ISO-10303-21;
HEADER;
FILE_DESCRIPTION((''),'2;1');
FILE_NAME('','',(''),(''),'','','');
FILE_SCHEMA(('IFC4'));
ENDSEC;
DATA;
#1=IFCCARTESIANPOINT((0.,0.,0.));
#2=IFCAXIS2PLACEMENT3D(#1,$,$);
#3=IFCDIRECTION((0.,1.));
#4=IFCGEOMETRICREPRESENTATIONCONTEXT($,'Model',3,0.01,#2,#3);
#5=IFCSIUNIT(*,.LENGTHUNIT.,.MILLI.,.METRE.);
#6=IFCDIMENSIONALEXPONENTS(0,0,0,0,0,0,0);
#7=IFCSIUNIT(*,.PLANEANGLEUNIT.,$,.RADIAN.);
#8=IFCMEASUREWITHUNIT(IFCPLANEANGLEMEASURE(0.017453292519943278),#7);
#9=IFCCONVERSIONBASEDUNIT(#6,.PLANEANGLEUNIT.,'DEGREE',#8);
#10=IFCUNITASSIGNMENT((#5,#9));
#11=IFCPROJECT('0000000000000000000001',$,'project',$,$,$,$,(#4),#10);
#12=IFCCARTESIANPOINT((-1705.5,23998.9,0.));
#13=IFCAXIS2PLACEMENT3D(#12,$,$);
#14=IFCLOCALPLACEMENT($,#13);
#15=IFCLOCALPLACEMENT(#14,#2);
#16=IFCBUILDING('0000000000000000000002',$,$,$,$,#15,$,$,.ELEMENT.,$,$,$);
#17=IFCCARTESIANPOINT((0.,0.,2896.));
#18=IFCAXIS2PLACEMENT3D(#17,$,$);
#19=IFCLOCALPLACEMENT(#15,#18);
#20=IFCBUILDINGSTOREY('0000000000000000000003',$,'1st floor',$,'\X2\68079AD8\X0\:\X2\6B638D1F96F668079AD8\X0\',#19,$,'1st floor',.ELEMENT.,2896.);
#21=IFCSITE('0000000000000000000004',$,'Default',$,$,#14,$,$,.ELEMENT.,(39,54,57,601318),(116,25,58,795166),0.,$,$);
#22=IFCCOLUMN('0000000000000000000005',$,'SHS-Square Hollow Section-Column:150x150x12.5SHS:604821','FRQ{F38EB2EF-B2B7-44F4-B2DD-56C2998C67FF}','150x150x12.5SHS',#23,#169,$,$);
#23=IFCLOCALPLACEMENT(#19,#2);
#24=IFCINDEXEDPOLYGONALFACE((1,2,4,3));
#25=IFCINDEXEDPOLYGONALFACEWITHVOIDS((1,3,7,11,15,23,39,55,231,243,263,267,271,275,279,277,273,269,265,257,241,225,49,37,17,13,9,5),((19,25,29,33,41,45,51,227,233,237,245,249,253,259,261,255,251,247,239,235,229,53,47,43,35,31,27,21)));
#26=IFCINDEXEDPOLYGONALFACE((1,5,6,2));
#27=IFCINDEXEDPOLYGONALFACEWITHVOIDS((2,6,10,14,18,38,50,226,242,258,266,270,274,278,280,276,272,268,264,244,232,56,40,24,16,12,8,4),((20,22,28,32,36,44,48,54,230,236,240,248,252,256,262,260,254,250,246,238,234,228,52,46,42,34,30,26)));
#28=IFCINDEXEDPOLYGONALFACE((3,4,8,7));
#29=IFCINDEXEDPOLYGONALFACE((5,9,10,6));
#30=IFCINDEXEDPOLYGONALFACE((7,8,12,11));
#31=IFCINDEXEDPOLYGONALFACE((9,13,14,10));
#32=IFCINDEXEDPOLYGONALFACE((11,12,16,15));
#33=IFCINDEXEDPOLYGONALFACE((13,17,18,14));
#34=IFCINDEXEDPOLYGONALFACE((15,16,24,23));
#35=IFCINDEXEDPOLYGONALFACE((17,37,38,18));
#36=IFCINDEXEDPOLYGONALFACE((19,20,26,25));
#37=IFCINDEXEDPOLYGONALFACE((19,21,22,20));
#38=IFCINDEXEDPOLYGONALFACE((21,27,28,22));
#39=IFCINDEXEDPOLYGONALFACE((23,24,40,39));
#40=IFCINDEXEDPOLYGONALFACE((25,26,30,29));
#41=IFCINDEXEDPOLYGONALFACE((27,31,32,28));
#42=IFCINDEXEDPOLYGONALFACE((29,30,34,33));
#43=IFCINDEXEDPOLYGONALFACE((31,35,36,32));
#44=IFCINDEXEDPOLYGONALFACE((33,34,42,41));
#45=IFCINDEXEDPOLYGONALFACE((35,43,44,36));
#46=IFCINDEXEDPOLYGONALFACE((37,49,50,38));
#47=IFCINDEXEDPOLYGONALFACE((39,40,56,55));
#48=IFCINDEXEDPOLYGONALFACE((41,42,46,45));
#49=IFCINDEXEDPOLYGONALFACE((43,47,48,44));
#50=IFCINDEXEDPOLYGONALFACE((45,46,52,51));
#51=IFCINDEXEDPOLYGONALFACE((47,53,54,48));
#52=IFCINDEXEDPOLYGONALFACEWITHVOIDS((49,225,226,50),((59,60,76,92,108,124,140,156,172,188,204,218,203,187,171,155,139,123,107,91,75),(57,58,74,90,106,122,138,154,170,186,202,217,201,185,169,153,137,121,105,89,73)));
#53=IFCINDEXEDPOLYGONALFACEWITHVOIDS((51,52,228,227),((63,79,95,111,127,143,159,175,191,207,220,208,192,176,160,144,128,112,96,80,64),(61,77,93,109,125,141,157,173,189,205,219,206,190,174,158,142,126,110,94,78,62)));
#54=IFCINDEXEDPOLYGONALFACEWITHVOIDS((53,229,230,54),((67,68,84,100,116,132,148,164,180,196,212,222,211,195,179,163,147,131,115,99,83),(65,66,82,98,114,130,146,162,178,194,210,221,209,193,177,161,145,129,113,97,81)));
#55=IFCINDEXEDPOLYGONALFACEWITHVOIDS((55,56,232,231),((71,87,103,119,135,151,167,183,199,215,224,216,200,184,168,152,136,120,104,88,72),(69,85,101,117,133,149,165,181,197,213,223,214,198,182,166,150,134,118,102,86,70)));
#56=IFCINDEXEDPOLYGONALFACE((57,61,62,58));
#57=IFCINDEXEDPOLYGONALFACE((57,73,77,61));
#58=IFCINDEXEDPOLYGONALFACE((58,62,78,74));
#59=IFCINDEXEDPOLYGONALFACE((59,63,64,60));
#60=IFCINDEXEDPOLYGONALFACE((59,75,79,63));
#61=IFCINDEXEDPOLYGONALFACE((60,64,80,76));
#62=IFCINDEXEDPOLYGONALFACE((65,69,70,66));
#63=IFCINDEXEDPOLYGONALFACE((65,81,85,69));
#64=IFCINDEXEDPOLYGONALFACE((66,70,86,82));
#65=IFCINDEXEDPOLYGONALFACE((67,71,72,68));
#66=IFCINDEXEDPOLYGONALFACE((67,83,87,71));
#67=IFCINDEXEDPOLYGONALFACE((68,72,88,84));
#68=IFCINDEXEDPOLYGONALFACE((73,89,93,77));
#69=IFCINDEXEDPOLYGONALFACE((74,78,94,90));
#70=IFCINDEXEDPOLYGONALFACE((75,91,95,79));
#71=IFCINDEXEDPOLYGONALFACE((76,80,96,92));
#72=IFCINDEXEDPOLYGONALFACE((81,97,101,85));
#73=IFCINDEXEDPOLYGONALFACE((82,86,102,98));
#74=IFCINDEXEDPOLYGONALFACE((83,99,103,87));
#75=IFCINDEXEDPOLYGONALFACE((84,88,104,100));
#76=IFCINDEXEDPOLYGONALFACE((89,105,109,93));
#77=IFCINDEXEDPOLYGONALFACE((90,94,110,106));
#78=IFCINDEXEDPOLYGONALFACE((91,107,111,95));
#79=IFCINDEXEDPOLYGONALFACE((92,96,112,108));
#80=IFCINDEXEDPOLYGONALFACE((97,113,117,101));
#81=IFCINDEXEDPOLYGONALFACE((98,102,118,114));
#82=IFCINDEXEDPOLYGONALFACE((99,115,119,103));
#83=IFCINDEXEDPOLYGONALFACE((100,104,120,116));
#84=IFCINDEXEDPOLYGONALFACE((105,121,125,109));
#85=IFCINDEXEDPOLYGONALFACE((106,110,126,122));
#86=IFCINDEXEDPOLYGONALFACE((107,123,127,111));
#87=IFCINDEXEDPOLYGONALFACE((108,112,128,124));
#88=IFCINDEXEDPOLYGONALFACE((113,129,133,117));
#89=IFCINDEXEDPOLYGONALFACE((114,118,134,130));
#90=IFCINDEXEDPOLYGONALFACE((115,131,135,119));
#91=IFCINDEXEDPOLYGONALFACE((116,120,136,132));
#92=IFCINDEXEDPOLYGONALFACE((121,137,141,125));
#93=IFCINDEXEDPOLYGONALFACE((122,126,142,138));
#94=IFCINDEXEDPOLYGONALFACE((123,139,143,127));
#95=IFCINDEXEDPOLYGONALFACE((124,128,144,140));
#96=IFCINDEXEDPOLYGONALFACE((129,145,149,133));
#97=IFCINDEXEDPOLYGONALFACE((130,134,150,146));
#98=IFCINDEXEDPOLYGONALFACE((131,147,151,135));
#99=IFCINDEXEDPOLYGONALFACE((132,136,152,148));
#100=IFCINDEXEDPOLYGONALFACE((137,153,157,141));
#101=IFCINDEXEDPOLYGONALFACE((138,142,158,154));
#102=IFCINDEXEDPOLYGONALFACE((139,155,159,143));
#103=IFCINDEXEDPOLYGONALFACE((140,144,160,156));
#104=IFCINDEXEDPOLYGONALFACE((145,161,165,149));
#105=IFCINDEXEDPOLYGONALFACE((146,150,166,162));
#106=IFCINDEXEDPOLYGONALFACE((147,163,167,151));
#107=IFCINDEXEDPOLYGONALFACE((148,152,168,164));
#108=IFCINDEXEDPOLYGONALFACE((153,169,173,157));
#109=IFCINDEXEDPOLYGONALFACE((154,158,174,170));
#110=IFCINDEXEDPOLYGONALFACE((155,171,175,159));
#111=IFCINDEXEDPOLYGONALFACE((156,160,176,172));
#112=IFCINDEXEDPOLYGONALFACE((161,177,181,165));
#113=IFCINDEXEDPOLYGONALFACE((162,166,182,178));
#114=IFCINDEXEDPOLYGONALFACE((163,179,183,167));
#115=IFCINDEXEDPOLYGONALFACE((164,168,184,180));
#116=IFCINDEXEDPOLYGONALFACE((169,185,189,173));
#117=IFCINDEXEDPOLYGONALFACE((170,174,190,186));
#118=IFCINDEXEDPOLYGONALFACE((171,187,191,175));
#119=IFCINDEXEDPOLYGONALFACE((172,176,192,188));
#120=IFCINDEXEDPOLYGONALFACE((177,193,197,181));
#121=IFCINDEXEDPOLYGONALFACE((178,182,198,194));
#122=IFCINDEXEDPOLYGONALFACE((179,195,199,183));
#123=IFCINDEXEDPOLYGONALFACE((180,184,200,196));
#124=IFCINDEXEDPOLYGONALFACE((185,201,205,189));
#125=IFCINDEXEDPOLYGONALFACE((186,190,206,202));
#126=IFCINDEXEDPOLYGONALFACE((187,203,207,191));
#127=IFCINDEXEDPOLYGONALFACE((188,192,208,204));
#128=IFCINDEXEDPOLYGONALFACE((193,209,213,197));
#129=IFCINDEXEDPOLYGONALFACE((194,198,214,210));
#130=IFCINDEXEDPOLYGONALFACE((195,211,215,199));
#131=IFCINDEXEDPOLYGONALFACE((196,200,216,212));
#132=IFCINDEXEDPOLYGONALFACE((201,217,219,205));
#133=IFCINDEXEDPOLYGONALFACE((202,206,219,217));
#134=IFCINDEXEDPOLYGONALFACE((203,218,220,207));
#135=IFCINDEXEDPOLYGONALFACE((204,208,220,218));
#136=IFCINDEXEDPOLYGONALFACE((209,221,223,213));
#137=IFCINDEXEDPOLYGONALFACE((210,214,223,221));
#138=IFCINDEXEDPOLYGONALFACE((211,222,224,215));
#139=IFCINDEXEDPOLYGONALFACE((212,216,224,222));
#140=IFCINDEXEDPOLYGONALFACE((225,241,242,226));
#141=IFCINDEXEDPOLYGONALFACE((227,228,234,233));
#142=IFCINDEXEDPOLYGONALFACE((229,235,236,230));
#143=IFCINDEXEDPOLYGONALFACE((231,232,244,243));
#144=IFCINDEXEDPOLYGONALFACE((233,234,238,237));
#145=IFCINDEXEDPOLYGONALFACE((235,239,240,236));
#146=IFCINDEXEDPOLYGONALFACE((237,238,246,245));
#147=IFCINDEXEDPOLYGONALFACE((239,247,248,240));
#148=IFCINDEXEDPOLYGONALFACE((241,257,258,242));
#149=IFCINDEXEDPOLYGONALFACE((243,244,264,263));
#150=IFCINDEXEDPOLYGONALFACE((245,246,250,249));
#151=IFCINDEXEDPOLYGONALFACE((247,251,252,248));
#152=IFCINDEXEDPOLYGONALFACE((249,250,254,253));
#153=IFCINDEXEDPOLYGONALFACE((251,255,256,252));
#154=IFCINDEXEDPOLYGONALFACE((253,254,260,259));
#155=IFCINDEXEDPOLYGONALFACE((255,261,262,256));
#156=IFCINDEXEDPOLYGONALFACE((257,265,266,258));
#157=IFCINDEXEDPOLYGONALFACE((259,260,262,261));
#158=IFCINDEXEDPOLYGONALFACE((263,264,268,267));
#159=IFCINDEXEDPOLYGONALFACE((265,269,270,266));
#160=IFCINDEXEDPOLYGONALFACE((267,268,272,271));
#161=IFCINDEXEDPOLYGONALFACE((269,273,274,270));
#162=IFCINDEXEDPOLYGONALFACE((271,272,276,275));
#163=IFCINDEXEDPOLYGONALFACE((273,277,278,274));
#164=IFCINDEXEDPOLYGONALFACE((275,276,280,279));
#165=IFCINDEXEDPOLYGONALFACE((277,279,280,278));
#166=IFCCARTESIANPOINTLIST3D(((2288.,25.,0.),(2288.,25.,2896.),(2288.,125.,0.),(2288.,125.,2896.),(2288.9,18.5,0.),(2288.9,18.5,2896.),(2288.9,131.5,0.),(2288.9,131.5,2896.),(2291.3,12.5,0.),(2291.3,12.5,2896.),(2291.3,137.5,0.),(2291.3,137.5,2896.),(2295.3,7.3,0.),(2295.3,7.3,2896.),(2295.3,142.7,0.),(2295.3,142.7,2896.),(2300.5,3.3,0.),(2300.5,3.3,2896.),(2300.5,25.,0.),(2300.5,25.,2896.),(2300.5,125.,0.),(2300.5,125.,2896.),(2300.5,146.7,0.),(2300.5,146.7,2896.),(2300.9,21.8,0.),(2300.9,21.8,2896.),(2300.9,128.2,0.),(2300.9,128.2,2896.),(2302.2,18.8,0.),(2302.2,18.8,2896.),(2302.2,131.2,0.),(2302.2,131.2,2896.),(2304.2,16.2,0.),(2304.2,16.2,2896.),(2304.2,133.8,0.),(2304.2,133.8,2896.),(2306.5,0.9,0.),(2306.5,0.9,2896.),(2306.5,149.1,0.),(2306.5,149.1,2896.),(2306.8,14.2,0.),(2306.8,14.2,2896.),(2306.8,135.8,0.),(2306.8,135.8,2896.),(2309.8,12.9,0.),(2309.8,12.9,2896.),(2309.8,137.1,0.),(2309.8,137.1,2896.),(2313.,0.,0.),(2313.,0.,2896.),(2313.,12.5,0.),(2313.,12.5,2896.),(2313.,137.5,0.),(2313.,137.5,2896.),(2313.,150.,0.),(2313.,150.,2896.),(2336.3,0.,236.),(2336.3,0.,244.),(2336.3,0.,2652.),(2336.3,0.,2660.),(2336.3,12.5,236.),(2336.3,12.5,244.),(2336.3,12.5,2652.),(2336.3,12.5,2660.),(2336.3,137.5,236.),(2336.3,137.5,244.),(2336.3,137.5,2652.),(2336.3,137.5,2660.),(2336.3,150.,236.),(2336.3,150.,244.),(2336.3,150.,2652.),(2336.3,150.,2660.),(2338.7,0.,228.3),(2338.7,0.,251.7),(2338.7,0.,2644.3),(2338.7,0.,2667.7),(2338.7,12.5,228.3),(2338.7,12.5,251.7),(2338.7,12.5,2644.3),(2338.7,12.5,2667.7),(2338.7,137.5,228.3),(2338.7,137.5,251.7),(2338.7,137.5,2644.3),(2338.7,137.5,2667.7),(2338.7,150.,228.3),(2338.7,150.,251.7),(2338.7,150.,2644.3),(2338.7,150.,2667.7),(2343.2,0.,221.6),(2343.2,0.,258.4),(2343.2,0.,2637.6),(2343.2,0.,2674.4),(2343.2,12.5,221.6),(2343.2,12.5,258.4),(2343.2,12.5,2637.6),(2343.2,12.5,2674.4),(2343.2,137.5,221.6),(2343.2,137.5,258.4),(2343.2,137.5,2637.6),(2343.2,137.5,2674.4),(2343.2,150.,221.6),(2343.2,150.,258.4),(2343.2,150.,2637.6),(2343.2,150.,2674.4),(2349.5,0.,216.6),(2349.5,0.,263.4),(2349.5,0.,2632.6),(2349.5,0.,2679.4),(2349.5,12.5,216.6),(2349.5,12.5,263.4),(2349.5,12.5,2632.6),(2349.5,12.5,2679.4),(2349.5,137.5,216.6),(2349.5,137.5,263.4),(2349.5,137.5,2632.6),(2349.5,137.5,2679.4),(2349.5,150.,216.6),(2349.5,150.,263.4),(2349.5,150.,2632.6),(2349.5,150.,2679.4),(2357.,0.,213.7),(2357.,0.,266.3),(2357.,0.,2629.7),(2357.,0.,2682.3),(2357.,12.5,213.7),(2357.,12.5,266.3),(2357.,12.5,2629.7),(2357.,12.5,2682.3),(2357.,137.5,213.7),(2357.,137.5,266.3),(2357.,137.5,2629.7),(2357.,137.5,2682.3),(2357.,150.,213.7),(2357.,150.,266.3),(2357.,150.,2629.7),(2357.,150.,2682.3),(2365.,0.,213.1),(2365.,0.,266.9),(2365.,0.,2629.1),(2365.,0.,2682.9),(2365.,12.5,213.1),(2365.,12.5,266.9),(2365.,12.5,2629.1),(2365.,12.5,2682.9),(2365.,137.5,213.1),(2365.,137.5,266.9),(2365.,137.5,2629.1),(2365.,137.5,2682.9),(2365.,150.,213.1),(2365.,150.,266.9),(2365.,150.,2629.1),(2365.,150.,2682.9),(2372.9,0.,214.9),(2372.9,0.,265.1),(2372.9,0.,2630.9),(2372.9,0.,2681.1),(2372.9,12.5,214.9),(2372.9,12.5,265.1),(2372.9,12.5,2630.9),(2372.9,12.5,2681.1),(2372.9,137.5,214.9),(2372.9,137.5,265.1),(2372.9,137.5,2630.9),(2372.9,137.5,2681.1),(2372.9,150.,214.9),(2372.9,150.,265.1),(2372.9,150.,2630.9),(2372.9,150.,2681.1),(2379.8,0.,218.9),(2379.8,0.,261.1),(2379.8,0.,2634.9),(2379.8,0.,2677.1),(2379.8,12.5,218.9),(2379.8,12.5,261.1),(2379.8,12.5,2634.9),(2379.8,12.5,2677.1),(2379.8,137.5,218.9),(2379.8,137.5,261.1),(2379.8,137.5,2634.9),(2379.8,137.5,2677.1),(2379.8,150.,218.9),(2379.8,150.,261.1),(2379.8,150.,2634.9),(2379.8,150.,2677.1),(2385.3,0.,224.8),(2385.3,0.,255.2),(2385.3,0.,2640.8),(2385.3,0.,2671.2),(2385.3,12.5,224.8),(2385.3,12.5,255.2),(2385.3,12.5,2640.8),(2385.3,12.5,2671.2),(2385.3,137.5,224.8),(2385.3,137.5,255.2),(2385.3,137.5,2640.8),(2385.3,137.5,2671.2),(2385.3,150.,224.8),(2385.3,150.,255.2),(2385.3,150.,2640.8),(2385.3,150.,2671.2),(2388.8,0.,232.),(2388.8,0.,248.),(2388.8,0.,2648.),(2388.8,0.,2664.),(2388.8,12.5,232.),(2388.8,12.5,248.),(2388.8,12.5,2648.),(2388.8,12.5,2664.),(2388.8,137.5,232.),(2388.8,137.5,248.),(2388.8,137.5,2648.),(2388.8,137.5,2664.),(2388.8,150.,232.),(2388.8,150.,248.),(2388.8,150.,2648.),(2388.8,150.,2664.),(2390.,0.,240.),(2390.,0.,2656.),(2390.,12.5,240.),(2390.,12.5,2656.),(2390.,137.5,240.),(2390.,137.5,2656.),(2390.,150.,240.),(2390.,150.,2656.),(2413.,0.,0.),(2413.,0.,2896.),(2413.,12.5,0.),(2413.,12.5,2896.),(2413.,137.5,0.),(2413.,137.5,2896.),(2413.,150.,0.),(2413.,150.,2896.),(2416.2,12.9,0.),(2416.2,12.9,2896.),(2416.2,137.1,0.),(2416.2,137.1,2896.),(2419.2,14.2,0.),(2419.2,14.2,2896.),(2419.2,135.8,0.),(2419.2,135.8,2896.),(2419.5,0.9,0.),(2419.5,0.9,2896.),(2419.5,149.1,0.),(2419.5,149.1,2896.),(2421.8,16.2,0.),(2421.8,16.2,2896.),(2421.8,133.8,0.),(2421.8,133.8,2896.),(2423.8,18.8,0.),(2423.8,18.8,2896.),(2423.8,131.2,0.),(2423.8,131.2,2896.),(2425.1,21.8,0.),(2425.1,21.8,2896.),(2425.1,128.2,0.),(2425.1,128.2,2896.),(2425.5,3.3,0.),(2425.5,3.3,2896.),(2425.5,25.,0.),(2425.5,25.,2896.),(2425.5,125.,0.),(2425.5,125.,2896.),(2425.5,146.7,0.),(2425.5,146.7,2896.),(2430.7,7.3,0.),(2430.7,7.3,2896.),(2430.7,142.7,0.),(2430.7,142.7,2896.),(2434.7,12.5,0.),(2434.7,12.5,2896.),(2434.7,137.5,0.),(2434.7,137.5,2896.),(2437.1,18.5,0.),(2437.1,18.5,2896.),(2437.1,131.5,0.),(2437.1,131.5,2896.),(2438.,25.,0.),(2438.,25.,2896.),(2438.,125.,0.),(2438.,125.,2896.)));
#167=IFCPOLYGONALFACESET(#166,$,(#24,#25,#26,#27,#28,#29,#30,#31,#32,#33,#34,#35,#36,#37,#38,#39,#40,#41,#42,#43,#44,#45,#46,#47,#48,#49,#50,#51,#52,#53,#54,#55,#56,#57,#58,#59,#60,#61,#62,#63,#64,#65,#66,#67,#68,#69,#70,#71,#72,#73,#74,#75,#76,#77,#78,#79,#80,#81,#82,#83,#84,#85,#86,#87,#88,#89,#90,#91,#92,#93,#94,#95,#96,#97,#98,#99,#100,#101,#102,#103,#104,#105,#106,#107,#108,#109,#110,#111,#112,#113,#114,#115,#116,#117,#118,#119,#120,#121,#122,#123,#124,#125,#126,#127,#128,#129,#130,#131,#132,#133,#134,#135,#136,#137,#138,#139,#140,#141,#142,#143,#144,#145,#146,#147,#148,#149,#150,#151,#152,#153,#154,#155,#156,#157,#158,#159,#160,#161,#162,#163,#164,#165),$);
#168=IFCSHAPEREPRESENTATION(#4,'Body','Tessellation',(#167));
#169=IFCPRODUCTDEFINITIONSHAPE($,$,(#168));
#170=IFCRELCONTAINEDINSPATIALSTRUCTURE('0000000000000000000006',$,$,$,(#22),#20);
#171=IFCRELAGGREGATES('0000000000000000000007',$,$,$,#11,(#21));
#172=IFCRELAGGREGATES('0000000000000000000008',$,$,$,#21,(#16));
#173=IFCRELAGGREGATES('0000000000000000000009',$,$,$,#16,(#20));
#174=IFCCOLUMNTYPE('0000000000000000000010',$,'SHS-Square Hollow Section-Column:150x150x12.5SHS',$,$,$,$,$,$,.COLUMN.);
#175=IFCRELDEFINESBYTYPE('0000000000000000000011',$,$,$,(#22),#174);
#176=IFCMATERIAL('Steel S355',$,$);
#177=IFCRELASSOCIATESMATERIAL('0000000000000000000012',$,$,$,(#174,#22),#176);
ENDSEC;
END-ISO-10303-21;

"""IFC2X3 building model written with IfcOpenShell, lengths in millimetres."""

from ifc_helpers import new_model, entity, si_unit, converted_unit, direction, frame, frame_2d, origin, origin_2d, place, context, project, spatial, circle_curve, hollow_rectangle, outline, extrude, material, type_object, element, save


model = new_model("IFC2X3")

# Units and contexts
model_context = context("Model", 3, precision=0.01, world=origin(), true_north=direction((0.0, 1.0)))
ifc_project = project(units=[si_unit("LENGTHUNIT", "METRE", prefix="MILLI"), converted_unit("PLANEANGLEUNIT", "DEGREE", entity("IfcPlaneAngleMeasure", 0.017453292519943278), si_unit("PLANEANGLEUNIT", "RADIAN"), dimensions=[0, 0, 0, 0, 0, 0, 0])], contexts=[model_context])

# Site, building, storey
site_placement = place(None, frame((-1705.5, 23998.9, 0.0)))
site = spatial("IfcSite", under=ifc_project, at=site_placement, Name="Default", CompositionType="ELEMENT", RefLatitude=(39, 54, 57, 601318), RefLongitude=(116, 25, 58, 795166), RefElevation=0.0)
building_placement = place(site_placement, origin())
building = spatial("IfcBuilding", under=site, at=building_placement, CompositionType="ELEMENT")
storey_placement = place(building_placement, frame((0.0, 0.0, 2896.0)))
storey = spatial("IfcBuildingStorey", under=building, at=storey_placement, Name="1st floor", ObjectType="标高:正负零标高", LongName="1st floor", CompositionType="ELEMENT", Elevation=2896.0)

# Column, openings
ifc_material_1 = material(Name="Steel S355")
column_type_1 = type_object("IfcColumnType", Name="SHS-Square Hollow Section-Column:150x150x12.5SHS", PredefinedType="COLUMN", material=ifc_material_1)
column_1_placement = place(storey_placement, frame((2363.0, 75.0, 2896.0), z_axis=(0.0, 0.0, 1.0), x_axis=(0.0, -1.0, 0.0)))
column_1 = element("IfcColumn", 1, at=column_1_placement, inside=storey, type_object=column_type_1, material=ifc_material_1, Name="SHS-Square Hollow Section-Column:150x150x12.5SHS:604821", Description="FRQ{F38EB2EF-B2B7-44F4-B2DD-56C2998C67FF}", ObjectType="150x150x12.5SHS", context=model_context, shape_type="SweptSolid", body=[
    extrude(hollow_rectangle(XDim=150.0, YDim=150.0, WallThickness=12.5, InnerFilletRadius=12.5, OuterFilletRadius=25.0, at=origin_2d()), origin(), (0.0, 0.0, -1.0), 2896.0),
])
opening_1_placement = place(column_1_placement, frame((-175.1, 0.0, 0.0), z_axis=(1.0, 0.0, 0.0), x_axis=(0.0, 1.0, 0.0)))
element("IfcOpeningElement", 2, at=opening_1_placement, cuts=column_1, ObjectType="Opening", context=model_context, shape_type="SweptSolid", body=[
    extrude(outline(circle_curve(frame_2d((0.0, -240.0), x_axis=(1.0, 0.0)), 27.0)), origin(), (0.0, 0.0, 1.0), 350.2),
])
opening_2_placement = place(column_1_placement, frame((-175.1, 0.0, -2896.0), z_axis=(1.0, 0.0, 0.0), x_axis=(0.0, 1.0, 0.0)))
element("IfcOpeningElement", 3, at=opening_2_placement, cuts=column_1, ObjectType="Opening", context=model_context, shape_type="SweptSolid", body=[
    extrude(outline(circle_curve(frame_2d((0.0, 240.0), x_axis=(1.0, 0.0)), 27.0)), origin(), (0.0, 0.0, 1.0), 350.2),
])

save(model, "model.ifc")
